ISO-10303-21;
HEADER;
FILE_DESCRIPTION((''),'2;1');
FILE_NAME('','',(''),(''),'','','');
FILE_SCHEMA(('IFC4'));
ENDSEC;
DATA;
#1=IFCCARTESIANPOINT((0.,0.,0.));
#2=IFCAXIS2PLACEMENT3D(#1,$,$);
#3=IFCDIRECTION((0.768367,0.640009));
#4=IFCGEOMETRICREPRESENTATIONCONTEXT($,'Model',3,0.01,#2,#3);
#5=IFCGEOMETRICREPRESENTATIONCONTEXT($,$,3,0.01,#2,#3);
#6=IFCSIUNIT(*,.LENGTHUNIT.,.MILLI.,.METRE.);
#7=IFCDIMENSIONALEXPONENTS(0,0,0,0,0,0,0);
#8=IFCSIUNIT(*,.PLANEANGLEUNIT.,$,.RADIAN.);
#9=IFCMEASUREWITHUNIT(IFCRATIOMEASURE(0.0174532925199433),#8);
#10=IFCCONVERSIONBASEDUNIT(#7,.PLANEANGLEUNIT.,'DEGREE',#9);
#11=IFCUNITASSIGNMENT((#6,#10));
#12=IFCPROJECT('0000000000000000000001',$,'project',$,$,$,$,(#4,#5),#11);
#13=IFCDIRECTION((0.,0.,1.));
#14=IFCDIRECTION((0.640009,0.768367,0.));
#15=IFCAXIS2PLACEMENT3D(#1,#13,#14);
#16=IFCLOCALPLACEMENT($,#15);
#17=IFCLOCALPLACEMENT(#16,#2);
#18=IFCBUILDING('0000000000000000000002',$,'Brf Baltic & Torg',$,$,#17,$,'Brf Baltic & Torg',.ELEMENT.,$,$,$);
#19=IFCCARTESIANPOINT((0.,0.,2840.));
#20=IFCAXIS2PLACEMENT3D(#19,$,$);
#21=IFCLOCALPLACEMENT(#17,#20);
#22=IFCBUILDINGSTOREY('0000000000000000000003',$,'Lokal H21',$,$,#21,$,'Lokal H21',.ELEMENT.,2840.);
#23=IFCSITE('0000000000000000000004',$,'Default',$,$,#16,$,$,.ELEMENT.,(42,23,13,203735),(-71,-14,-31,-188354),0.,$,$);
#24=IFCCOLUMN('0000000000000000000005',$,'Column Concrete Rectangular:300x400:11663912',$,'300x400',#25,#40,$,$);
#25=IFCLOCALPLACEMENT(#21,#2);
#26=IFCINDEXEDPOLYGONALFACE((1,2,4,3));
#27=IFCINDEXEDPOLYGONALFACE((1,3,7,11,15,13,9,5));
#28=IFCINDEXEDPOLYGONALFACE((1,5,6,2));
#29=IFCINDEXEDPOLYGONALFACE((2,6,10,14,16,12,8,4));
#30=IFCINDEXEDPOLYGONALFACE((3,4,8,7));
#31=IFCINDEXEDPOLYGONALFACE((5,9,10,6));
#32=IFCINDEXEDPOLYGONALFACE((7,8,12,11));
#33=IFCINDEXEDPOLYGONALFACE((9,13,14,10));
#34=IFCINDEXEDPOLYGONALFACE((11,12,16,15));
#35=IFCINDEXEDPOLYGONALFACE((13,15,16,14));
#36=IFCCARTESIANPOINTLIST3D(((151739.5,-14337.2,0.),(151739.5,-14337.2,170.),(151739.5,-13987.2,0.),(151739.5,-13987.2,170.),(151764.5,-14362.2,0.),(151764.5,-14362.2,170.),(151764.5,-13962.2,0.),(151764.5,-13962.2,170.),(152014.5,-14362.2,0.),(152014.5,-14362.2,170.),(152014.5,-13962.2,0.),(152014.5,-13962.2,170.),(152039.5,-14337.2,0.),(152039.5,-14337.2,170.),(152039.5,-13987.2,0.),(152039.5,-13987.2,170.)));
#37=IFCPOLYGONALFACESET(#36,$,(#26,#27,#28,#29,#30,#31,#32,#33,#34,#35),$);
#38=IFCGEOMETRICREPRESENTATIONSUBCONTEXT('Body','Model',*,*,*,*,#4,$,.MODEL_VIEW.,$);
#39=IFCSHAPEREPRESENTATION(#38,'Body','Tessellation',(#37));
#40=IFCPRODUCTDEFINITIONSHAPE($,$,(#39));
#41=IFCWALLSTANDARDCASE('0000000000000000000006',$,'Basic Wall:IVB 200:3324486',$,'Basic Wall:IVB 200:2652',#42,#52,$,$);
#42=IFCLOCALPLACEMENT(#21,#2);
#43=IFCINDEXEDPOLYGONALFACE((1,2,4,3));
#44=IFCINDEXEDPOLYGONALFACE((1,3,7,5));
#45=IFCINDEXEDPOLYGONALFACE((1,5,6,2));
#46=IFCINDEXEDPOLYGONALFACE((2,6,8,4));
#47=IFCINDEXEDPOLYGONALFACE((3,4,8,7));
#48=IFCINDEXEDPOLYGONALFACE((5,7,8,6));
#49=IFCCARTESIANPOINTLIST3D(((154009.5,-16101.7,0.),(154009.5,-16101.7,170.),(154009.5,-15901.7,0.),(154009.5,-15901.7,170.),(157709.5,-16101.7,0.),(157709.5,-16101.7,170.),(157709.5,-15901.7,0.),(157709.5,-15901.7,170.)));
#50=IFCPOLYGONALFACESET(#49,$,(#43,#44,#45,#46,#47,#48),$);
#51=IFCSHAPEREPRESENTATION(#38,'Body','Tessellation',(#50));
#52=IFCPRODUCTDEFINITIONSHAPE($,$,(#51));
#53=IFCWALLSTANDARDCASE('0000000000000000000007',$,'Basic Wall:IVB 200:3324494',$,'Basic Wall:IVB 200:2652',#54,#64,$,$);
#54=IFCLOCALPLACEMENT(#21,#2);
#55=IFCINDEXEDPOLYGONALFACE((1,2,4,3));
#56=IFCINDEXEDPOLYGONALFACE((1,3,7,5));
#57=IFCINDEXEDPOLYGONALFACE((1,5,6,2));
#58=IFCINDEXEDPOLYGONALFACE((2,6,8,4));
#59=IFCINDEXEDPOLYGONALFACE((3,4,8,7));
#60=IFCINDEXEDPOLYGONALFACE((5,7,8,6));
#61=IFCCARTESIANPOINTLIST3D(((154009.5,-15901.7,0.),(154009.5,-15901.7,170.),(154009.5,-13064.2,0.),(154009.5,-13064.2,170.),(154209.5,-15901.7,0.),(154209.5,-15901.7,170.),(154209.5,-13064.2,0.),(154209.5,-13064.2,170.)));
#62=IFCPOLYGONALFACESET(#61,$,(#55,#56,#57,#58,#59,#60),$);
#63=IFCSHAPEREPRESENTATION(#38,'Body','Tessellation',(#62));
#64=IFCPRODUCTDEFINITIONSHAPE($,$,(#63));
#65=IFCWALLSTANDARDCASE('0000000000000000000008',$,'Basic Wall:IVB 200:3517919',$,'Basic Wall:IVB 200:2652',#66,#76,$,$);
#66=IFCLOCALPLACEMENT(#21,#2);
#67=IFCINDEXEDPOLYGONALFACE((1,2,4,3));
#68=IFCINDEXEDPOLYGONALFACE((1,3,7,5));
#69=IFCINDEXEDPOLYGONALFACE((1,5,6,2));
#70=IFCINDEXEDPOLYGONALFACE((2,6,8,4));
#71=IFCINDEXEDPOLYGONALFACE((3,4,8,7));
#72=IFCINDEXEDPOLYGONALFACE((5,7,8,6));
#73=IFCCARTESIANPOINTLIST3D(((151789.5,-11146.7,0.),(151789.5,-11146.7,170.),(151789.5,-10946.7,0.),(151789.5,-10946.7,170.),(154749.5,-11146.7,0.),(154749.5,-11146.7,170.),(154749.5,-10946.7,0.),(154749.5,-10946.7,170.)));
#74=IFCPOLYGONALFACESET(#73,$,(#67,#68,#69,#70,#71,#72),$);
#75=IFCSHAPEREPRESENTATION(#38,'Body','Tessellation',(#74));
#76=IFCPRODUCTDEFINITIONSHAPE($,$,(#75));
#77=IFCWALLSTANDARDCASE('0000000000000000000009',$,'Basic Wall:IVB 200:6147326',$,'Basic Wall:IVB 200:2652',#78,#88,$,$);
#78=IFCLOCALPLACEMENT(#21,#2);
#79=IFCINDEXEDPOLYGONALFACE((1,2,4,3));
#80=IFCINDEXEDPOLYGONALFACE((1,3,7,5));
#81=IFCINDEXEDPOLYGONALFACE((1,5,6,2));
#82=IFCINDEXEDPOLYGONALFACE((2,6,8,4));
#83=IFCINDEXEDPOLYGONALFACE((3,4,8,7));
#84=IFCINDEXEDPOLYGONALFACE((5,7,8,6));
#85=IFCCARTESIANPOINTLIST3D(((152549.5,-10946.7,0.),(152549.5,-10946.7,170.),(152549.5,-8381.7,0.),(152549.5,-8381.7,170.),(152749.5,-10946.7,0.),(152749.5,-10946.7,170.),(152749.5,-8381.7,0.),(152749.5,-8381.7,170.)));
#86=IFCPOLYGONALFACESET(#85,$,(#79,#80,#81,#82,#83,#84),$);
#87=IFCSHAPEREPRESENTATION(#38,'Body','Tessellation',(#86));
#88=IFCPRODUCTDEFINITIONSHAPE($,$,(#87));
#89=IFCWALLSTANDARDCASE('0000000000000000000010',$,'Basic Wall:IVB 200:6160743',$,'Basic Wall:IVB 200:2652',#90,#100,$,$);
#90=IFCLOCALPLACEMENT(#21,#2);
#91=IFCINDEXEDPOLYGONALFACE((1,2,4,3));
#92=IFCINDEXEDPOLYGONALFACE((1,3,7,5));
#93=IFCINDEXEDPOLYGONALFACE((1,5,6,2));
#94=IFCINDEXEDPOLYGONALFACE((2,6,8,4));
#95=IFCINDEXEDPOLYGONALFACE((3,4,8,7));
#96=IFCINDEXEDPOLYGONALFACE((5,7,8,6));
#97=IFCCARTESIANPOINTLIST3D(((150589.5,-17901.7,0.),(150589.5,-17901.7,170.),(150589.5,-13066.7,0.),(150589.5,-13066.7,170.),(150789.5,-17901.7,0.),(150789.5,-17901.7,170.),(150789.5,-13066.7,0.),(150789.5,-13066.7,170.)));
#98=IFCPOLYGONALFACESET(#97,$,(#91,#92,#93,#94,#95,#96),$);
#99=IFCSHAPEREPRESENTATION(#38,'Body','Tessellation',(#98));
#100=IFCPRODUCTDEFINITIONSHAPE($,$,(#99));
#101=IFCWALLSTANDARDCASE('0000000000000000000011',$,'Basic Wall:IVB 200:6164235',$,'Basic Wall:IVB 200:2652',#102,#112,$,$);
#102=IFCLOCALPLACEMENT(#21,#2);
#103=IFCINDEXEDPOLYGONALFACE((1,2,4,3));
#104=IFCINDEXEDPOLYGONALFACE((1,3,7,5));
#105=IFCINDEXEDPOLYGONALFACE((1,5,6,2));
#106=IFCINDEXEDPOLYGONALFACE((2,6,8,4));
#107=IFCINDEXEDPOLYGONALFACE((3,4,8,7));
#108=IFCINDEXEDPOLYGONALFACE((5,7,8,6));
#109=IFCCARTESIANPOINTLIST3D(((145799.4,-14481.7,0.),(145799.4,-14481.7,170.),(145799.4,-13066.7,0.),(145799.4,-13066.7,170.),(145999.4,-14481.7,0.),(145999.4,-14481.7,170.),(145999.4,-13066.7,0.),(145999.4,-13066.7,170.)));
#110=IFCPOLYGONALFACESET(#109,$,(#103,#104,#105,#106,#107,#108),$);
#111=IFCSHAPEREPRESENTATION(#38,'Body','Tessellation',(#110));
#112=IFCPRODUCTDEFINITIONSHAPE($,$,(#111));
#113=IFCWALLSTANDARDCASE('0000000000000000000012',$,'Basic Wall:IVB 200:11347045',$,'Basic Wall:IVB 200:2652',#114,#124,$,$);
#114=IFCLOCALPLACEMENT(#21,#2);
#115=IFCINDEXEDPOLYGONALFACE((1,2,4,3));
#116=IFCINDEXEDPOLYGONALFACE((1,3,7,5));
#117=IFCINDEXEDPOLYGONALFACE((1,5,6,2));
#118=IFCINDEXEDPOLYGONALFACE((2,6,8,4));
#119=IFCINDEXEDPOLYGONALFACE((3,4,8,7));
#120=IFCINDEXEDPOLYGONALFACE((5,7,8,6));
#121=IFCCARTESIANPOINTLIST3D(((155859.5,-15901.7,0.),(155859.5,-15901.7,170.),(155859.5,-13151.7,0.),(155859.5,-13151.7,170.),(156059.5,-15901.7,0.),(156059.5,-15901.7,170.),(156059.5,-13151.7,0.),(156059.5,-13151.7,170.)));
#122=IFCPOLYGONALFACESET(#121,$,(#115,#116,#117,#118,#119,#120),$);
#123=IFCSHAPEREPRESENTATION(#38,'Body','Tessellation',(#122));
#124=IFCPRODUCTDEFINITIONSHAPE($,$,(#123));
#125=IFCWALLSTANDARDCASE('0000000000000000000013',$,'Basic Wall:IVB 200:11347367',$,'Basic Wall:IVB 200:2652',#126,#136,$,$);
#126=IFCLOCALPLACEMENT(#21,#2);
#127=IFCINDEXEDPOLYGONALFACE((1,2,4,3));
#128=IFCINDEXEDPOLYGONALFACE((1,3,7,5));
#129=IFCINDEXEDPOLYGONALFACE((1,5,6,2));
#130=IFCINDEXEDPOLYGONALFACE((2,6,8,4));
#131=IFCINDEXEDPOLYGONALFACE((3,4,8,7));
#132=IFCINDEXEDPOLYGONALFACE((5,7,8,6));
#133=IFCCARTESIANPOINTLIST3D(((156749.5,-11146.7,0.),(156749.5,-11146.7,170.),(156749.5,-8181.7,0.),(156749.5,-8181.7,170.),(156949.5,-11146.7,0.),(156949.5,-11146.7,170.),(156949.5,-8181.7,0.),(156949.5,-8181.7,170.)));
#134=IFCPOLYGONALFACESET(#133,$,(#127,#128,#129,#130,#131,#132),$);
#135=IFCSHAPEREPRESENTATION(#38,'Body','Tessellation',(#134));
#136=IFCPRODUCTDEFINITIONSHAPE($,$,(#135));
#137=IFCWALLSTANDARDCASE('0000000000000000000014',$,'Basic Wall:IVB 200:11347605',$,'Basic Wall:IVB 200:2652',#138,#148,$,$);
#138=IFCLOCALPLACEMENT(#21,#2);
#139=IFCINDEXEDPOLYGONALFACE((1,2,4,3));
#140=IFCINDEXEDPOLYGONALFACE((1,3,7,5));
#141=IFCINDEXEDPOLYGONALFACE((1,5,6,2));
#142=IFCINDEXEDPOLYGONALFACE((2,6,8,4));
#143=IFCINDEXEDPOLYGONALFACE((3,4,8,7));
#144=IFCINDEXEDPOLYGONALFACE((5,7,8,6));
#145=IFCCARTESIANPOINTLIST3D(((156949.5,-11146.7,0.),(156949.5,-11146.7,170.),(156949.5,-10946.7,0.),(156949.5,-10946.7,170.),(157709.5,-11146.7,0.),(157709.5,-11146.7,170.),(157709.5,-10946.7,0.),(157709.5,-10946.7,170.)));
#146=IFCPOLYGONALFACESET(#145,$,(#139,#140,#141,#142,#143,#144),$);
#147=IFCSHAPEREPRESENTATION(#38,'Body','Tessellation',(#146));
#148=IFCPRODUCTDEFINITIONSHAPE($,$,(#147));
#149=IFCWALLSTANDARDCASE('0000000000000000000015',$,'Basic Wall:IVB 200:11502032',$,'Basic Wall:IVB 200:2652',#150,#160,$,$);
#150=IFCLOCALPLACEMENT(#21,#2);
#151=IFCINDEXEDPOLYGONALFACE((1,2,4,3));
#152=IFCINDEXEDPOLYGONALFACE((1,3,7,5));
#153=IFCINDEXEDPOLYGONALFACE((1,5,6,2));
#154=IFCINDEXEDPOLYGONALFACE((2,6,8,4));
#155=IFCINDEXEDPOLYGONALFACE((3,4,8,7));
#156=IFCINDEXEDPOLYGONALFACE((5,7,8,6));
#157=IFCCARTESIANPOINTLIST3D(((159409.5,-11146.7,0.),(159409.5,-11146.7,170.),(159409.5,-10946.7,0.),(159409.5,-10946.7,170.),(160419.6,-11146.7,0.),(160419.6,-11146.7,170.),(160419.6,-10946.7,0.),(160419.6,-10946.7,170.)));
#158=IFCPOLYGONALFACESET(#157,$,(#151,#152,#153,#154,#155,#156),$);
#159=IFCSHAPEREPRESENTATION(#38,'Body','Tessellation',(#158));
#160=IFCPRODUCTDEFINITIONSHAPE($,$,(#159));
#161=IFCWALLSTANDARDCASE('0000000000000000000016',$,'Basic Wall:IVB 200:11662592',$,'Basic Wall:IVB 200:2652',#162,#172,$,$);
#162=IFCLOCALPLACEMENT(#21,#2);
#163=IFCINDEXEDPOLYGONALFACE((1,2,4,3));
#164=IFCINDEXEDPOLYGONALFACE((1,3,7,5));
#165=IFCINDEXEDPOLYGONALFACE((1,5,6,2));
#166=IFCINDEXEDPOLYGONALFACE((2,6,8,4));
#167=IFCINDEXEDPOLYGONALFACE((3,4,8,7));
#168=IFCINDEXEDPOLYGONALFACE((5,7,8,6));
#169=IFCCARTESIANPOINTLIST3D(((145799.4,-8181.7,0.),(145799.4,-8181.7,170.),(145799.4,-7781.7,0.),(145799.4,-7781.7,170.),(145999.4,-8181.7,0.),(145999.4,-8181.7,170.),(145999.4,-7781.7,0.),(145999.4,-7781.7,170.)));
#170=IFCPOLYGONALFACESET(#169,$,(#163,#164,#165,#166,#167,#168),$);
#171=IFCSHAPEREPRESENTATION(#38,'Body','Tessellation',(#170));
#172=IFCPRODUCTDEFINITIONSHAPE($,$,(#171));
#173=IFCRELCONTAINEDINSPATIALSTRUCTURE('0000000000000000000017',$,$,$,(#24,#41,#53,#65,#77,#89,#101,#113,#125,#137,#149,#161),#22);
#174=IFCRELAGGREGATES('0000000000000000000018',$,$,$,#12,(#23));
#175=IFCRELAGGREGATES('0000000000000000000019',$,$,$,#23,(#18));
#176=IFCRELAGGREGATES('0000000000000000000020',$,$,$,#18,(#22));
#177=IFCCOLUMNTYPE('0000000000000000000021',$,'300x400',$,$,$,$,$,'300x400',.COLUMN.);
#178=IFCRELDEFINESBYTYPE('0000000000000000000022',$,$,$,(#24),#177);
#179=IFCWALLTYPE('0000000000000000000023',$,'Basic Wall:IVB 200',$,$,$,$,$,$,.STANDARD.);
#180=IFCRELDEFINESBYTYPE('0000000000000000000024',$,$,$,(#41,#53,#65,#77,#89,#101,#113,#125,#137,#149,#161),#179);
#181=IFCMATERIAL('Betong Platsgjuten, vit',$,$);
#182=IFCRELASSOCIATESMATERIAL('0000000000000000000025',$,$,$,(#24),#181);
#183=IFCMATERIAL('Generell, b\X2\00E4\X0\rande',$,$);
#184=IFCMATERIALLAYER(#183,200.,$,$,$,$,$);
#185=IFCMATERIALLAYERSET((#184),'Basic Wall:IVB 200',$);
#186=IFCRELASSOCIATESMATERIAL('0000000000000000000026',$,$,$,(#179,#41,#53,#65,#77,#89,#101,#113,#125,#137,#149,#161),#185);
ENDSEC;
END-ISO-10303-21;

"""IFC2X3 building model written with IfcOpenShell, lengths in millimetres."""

from ifc_helpers import new_model, entity, si_unit, converted_unit, direction, frame, frame_2d, origin, place, context, subcontext, project, spatial, polyline, rectangle, outline, extrude, clip, halfspace, source, transform, mapped, material, layer, layer_set, layer_usage, type_object, type_shapes, element, save


model = new_model("IFC2X3")

# Units and contexts
model_context = context("Model", 3, precision=0.01, world=origin(), true_north=direction((0.768367, 0.640009)))
context_of_model = context(None, 3, precision=0.01, world=origin(), true_north=direction((0.768367, 0.640009)))
body_context = subcontext(model_context, "Body", "Model", "MODEL_VIEW")
ifc_project = project(units=[si_unit("LENGTHUNIT", "METRE", prefix="MILLI"), converted_unit("PLANEANGLEUNIT", "DEGREE", entity("IfcRatioMeasure", 0.0174532925199433), si_unit("PLANEANGLEUNIT", "RADIAN"), dimensions=[0, 0, 0, 0, 0, 0, 0])], contexts=[model_context, context_of_model])

# Site, building, storey
site_placement = place(None, frame((0.0, 0.0, 0.0), z_axis=(0.0, 0.0, 1.0), x_axis=(0.640009, 0.768367, 0.0)))
site = spatial("IfcSite", under=ifc_project, at=site_placement, Name="Default", CompositionType="ELEMENT", RefLatitude=(42, 23, 13, 203735), RefLongitude=(-71, -14, -31, -188354), RefElevation=0.0)
building_placement = place(site_placement, origin())
building = spatial("IfcBuilding", under=site, at=building_placement, Name="Brf Baltic & Torg", LongName="Brf Baltic & Torg", CompositionType="ELEMENT")
storey_placement = place(building_placement, frame((0.0, 0.0, 2840.0)))
storey = spatial("IfcBuildingStorey", under=building, at=storey_placement, Name="Lokal H21", LongName="Lokal H21", CompositionType="ELEMENT", Elevation=2840.0)

# Column
ifc_material_1 = material(Name="Betong Platsgjuten, vit")
column_type_1 = type_object("IfcColumnType", Name="300x400", ElementType="300x400", PredefinedType="COLUMN")
shared_shape_1 = source(origin(), body_context, "Body", "SweptSolid", [
    extrude(outline(polyline([(-175.0, -150.0), (175.0, -150.0), (200.0, -125.0), (200.0, 125.0), (175.0, 150.0), (-175.0, 150.0), (-200.0, 125.0), (-200.0, -125.0), (-175.0, -150.0)])), frame((0.0, 0.0, 2840.0), z_axis=(0.0, 0.0, 1.0), x_axis=(0.0, -1.0, 0.0)), (0.0, 0.0, 1.0), 170.0),
])
type_shapes(column_type_1, [shared_shape_1])
column_1_placement = place(storey_placement, frame((151889.5, -14162.2, -2840.0)))
element("IfcColumn", 1, at=column_1_placement, inside=storey, type_object=column_type_1, material=ifc_material_1, Name="Column Concrete Rectangular:300x400:11663912", ObjectType="300x400", context=body_context, shape_type="MappedRepresentation", body=[
    mapped(shared_shape_1, transform((0.0, 0.0, 0.0), scale=1.0)),
])

# Walls
ifc_material_2 = material(Name="Generell, bärande")
ifc_layer = layer(ifc_material_2, 200.0)
ifc_layer_set = layer_set([ifc_layer], Name="Basic Wall:IVB 200")
ifc_layer_usage_1 = layer_usage(ifc_layer_set, "AXIS2", "NEGATIVE", 100.0)
wall_type = type_object("IfcWallType", Name="Basic Wall:IVB 200", PredefinedType="STANDARD", material=ifc_layer_set)
wall_1_placement = place(storey_placement, frame((157709.5, -16001.7, 0.0), z_axis=(0.0, 0.0, 1.0), x_axis=(-1.0, 0.0, 0.0)))
element("IfcWallStandardCase", 2, at=wall_1_placement, inside=storey, type_object=wall_type, material=ifc_layer_usage_1, Name="Basic Wall:IVB 200:3324486", ObjectType="Basic Wall:IVB 200:2652", context=body_context, shape_type="Clipping", body=[
    clip(extrude(rectangle(XDim=3700.0, YDim=200.0, at=frame_2d((1850.0, 0.0), x_axis=(-1.0, 0.0))), origin(), (0.0, 0.0, 1.0), 170.0), halfspace(frame((0.0, 0.0, -1190.0)), True)),
])
ifc_layer_usage_2 = layer_usage(ifc_layer_set, "AXIS2", "NEGATIVE", 100.0)
wall_2_placement = place(storey_placement, frame((154109.5, -15901.7, 0.0), z_axis=(0.0, 0.0, 1.0), x_axis=(0.0, 1.0, 0.0)))
element("IfcWallStandardCase", 3, at=wall_2_placement, inside=storey, type_object=wall_type, material=ifc_layer_usage_2, Name="Basic Wall:IVB 200:3324494", ObjectType="Basic Wall:IVB 200:2652", context=body_context, shape_type="Clipping", body=[
    clip(extrude(rectangle(XDim=2837.5, YDim=200.0, at=frame_2d((1418.7, 0.0), x_axis=(-1.0, 0.0))), origin(), (0.0, 0.0, 1.0), 170.0), halfspace(frame((0.0, 0.0, -1190.0)), True)),
])

# Wall
ifc_layer_usage_3 = layer_usage(ifc_layer_set, "AXIS2", "NEGATIVE", 100.0)
wall_3_placement = place(storey_placement, frame((151789.5, -11046.7, 0.0)))
element("IfcWallStandardCase", 4, at=wall_3_placement, inside=storey, type_object=wall_type, material=ifc_layer_usage_3, Name="Basic Wall:IVB 200:3517919", ObjectType="Basic Wall:IVB 200:2652", context=body_context, shape_type="Clipping", body=[
    clip(extrude(rectangle(XDim=2960.0, YDim=200.0, at=frame_2d((1480.0, 0.0), x_axis=(-1.0, 0.0))), origin(), (0.0, 0.0, 1.0), 170.0), halfspace(frame((0.0, 0.0, -1190.0)), True)),
])

# Walls
ifc_layer_usage_4 = layer_usage(ifc_layer_set, "AXIS2", "NEGATIVE", 100.0)
wall_4_placement = place(storey_placement, frame((152649.5, -10946.7, 0.0), z_axis=(0.0, 0.0, 1.0), x_axis=(0.0, 1.0, 0.0)))
element("IfcWallStandardCase", 5, at=wall_4_placement, inside=storey, type_object=wall_type, material=ifc_layer_usage_4, Name="Basic Wall:IVB 200:6147326", ObjectType="Basic Wall:IVB 200:2652", context=body_context, shape_type="Clipping", body=[
    clip(extrude(rectangle(XDim=2565.0, YDim=200.0, at=frame_2d((1282.5, 0.0), x_axis=(-1.0, 0.0))), origin(), (0.0, 0.0, 1.0), 170.0), halfspace(frame((0.0, 0.0, -1190.0)), True)),
])
ifc_layer_usage_5 = layer_usage(ifc_layer_set, "AXIS2", "POSITIVE", -100.0)
wall_5_placement = place(storey_placement, frame((150689.5, -13066.7, 0.0), z_axis=(0.0, 0.0, 1.0), x_axis=(0.0, -1.0, 0.0)))
element("IfcWallStandardCase", 6, at=wall_5_placement, inside=storey, type_object=wall_type, material=ifc_layer_usage_5, Name="Basic Wall:IVB 200:6160743", ObjectType="Basic Wall:IVB 200:2652", context=body_context, shape_type="Clipping", body=[
    clip(extrude(rectangle(XDim=4835.0, YDim=200.0, at=frame_2d((2417.5, 0.0), x_axis=(-1.0, 0.0))), origin(), (0.0, 0.0, 1.0), 170.0), halfspace(frame((0.0, 0.0, -1190.0)), True)),
])
ifc_layer_usage_6 = layer_usage(ifc_layer_set, "AXIS2", "POSITIVE", -100.0)
wall_6_placement = place(storey_placement, frame((145899.4, -13066.7, 0.0), z_axis=(0.0, 0.0, 1.0), x_axis=(0.0, -1.0, 0.0)))
element("IfcWallStandardCase", 7, at=wall_6_placement, inside=storey, type_object=wall_type, material=ifc_layer_usage_6, Name="Basic Wall:IVB 200:6164235", ObjectType="Basic Wall:IVB 200:2652", context=body_context, shape_type="Clipping", body=[
    clip(extrude(rectangle(XDim=1415.0, YDim=200.0, at=frame_2d((707.5, 0.0), x_axis=(-1.0, 0.0))), origin(), (0.0, 0.0, 1.0), 170.0), halfspace(frame((0.0, 0.0, -1190.0)), True)),
])

# Walls
ifc_layer_usage_7 = layer_usage(ifc_layer_set, "AXIS2", "NEGATIVE", 100.0)
wall_7_placement = place(storey_placement, frame((155959.5, -15901.7, 0.0), z_axis=(0.0, 0.0, 1.0), x_axis=(0.0, 1.0, 0.0)))
element("IfcWallStandardCase", 8, at=wall_7_placement, inside=storey, type_object=wall_type, material=ifc_layer_usage_7, Name="Basic Wall:IVB 200:11347045", ObjectType="Basic Wall:IVB 200:2652", context=body_context, shape_type="Clipping", body=[
    clip(extrude(rectangle(XDim=2750.0, YDim=200.0, at=frame_2d((1375.0, 0.0), x_axis=(-1.0, 0.0))), origin(), (0.0, 0.0, 1.0), 170.0), halfspace(frame((0.0, 0.0, -1190.0)), True)),
])
ifc_layer_usage_8 = layer_usage(ifc_layer_set, "AXIS2", "POSITIVE", -100.0)
wall_8_placement = place(storey_placement, frame((156849.5, -8181.7, 0.0), z_axis=(0.0, 0.0, 1.0), x_axis=(0.0, -1.0, 0.0)))
element("IfcWallStandardCase", 9, at=wall_8_placement, inside=storey, type_object=wall_type, material=ifc_layer_usage_8, Name="Basic Wall:IVB 200:11347367", ObjectType="Basic Wall:IVB 200:2652", context=body_context, shape_type="Clipping", body=[
    clip(extrude(rectangle(XDim=2965.0, YDim=200.0, at=frame_2d((1482.5, 0.0), x_axis=(-1.0, 0.0))), origin(), (0.0, 0.0, 1.0), 170.0), halfspace(frame((0.0, 0.0, -1190.0)), True)),
])
ifc_layer_usage_9 = layer_usage(ifc_layer_set, "AXIS2", "NEGATIVE", 100.0)
wall_9_placement = place(storey_placement, frame((156949.5, -11046.7, 0.0)))
element("IfcWallStandardCase", 10, at=wall_9_placement, inside=storey, type_object=wall_type, material=ifc_layer_usage_9, Name="Basic Wall:IVB 200:11347605", ObjectType="Basic Wall:IVB 200:2652", context=body_context, shape_type="Clipping", body=[
    clip(extrude(rectangle(XDim=760.0, YDim=200.0, at=frame_2d((380.0, 0.0), x_axis=(-1.0, 0.0))), origin(), (0.0, 0.0, 1.0), 170.0), halfspace(frame((0.0, 0.0, -1190.0)), True)),
])

# Walls
ifc_layer_usage_10 = layer_usage(ifc_layer_set, "AXIS2", "NEGATIVE", 100.0)
wall_10_placement = place(storey_placement, frame((159409.5, -11046.7, 0.0)))
element("IfcWallStandardCase", 11, at=wall_10_placement, inside=storey, type_object=wall_type, material=ifc_layer_usage_10, Name="Basic Wall:IVB 200:11502032", ObjectType="Basic Wall:IVB 200:2652", context=body_context, shape_type="Clipping", body=[
    clip(extrude(rectangle(XDim=1010.1, YDim=200.0, at=frame_2d((505.0, 0.0), x_axis=(-1.0, 0.0))), origin(), (0.0, 0.0, 1.0), 170.0), halfspace(frame((0.0, 0.0, -1190.0)), True)),
])
ifc_layer_usage_11 = layer_usage(ifc_layer_set, "AXIS2", "POSITIVE", -100.0)
wall_11_placement = place(storey_placement, frame((145899.4, -7781.7, 0.0), z_axis=(0.0, 0.0, 1.0), x_axis=(0.0, -1.0, 0.0)))
element("IfcWallStandardCase", 12, at=wall_11_placement, inside=storey, type_object=wall_type, material=ifc_layer_usage_11, Name="Basic Wall:IVB 200:11662592", ObjectType="Basic Wall:IVB 200:2652", context=body_context, shape_type="Clipping", body=[
    clip(extrude(rectangle(XDim=400.0, YDim=200.0, at=frame_2d((200.0, 0.0), x_axis=(-1.0, 0.0))), origin(), (0.0, 0.0, 1.0), 170.0), halfspace(frame((0.0, 0.0, -1190.0)), True)),
])

save(model, "model.ifc")
